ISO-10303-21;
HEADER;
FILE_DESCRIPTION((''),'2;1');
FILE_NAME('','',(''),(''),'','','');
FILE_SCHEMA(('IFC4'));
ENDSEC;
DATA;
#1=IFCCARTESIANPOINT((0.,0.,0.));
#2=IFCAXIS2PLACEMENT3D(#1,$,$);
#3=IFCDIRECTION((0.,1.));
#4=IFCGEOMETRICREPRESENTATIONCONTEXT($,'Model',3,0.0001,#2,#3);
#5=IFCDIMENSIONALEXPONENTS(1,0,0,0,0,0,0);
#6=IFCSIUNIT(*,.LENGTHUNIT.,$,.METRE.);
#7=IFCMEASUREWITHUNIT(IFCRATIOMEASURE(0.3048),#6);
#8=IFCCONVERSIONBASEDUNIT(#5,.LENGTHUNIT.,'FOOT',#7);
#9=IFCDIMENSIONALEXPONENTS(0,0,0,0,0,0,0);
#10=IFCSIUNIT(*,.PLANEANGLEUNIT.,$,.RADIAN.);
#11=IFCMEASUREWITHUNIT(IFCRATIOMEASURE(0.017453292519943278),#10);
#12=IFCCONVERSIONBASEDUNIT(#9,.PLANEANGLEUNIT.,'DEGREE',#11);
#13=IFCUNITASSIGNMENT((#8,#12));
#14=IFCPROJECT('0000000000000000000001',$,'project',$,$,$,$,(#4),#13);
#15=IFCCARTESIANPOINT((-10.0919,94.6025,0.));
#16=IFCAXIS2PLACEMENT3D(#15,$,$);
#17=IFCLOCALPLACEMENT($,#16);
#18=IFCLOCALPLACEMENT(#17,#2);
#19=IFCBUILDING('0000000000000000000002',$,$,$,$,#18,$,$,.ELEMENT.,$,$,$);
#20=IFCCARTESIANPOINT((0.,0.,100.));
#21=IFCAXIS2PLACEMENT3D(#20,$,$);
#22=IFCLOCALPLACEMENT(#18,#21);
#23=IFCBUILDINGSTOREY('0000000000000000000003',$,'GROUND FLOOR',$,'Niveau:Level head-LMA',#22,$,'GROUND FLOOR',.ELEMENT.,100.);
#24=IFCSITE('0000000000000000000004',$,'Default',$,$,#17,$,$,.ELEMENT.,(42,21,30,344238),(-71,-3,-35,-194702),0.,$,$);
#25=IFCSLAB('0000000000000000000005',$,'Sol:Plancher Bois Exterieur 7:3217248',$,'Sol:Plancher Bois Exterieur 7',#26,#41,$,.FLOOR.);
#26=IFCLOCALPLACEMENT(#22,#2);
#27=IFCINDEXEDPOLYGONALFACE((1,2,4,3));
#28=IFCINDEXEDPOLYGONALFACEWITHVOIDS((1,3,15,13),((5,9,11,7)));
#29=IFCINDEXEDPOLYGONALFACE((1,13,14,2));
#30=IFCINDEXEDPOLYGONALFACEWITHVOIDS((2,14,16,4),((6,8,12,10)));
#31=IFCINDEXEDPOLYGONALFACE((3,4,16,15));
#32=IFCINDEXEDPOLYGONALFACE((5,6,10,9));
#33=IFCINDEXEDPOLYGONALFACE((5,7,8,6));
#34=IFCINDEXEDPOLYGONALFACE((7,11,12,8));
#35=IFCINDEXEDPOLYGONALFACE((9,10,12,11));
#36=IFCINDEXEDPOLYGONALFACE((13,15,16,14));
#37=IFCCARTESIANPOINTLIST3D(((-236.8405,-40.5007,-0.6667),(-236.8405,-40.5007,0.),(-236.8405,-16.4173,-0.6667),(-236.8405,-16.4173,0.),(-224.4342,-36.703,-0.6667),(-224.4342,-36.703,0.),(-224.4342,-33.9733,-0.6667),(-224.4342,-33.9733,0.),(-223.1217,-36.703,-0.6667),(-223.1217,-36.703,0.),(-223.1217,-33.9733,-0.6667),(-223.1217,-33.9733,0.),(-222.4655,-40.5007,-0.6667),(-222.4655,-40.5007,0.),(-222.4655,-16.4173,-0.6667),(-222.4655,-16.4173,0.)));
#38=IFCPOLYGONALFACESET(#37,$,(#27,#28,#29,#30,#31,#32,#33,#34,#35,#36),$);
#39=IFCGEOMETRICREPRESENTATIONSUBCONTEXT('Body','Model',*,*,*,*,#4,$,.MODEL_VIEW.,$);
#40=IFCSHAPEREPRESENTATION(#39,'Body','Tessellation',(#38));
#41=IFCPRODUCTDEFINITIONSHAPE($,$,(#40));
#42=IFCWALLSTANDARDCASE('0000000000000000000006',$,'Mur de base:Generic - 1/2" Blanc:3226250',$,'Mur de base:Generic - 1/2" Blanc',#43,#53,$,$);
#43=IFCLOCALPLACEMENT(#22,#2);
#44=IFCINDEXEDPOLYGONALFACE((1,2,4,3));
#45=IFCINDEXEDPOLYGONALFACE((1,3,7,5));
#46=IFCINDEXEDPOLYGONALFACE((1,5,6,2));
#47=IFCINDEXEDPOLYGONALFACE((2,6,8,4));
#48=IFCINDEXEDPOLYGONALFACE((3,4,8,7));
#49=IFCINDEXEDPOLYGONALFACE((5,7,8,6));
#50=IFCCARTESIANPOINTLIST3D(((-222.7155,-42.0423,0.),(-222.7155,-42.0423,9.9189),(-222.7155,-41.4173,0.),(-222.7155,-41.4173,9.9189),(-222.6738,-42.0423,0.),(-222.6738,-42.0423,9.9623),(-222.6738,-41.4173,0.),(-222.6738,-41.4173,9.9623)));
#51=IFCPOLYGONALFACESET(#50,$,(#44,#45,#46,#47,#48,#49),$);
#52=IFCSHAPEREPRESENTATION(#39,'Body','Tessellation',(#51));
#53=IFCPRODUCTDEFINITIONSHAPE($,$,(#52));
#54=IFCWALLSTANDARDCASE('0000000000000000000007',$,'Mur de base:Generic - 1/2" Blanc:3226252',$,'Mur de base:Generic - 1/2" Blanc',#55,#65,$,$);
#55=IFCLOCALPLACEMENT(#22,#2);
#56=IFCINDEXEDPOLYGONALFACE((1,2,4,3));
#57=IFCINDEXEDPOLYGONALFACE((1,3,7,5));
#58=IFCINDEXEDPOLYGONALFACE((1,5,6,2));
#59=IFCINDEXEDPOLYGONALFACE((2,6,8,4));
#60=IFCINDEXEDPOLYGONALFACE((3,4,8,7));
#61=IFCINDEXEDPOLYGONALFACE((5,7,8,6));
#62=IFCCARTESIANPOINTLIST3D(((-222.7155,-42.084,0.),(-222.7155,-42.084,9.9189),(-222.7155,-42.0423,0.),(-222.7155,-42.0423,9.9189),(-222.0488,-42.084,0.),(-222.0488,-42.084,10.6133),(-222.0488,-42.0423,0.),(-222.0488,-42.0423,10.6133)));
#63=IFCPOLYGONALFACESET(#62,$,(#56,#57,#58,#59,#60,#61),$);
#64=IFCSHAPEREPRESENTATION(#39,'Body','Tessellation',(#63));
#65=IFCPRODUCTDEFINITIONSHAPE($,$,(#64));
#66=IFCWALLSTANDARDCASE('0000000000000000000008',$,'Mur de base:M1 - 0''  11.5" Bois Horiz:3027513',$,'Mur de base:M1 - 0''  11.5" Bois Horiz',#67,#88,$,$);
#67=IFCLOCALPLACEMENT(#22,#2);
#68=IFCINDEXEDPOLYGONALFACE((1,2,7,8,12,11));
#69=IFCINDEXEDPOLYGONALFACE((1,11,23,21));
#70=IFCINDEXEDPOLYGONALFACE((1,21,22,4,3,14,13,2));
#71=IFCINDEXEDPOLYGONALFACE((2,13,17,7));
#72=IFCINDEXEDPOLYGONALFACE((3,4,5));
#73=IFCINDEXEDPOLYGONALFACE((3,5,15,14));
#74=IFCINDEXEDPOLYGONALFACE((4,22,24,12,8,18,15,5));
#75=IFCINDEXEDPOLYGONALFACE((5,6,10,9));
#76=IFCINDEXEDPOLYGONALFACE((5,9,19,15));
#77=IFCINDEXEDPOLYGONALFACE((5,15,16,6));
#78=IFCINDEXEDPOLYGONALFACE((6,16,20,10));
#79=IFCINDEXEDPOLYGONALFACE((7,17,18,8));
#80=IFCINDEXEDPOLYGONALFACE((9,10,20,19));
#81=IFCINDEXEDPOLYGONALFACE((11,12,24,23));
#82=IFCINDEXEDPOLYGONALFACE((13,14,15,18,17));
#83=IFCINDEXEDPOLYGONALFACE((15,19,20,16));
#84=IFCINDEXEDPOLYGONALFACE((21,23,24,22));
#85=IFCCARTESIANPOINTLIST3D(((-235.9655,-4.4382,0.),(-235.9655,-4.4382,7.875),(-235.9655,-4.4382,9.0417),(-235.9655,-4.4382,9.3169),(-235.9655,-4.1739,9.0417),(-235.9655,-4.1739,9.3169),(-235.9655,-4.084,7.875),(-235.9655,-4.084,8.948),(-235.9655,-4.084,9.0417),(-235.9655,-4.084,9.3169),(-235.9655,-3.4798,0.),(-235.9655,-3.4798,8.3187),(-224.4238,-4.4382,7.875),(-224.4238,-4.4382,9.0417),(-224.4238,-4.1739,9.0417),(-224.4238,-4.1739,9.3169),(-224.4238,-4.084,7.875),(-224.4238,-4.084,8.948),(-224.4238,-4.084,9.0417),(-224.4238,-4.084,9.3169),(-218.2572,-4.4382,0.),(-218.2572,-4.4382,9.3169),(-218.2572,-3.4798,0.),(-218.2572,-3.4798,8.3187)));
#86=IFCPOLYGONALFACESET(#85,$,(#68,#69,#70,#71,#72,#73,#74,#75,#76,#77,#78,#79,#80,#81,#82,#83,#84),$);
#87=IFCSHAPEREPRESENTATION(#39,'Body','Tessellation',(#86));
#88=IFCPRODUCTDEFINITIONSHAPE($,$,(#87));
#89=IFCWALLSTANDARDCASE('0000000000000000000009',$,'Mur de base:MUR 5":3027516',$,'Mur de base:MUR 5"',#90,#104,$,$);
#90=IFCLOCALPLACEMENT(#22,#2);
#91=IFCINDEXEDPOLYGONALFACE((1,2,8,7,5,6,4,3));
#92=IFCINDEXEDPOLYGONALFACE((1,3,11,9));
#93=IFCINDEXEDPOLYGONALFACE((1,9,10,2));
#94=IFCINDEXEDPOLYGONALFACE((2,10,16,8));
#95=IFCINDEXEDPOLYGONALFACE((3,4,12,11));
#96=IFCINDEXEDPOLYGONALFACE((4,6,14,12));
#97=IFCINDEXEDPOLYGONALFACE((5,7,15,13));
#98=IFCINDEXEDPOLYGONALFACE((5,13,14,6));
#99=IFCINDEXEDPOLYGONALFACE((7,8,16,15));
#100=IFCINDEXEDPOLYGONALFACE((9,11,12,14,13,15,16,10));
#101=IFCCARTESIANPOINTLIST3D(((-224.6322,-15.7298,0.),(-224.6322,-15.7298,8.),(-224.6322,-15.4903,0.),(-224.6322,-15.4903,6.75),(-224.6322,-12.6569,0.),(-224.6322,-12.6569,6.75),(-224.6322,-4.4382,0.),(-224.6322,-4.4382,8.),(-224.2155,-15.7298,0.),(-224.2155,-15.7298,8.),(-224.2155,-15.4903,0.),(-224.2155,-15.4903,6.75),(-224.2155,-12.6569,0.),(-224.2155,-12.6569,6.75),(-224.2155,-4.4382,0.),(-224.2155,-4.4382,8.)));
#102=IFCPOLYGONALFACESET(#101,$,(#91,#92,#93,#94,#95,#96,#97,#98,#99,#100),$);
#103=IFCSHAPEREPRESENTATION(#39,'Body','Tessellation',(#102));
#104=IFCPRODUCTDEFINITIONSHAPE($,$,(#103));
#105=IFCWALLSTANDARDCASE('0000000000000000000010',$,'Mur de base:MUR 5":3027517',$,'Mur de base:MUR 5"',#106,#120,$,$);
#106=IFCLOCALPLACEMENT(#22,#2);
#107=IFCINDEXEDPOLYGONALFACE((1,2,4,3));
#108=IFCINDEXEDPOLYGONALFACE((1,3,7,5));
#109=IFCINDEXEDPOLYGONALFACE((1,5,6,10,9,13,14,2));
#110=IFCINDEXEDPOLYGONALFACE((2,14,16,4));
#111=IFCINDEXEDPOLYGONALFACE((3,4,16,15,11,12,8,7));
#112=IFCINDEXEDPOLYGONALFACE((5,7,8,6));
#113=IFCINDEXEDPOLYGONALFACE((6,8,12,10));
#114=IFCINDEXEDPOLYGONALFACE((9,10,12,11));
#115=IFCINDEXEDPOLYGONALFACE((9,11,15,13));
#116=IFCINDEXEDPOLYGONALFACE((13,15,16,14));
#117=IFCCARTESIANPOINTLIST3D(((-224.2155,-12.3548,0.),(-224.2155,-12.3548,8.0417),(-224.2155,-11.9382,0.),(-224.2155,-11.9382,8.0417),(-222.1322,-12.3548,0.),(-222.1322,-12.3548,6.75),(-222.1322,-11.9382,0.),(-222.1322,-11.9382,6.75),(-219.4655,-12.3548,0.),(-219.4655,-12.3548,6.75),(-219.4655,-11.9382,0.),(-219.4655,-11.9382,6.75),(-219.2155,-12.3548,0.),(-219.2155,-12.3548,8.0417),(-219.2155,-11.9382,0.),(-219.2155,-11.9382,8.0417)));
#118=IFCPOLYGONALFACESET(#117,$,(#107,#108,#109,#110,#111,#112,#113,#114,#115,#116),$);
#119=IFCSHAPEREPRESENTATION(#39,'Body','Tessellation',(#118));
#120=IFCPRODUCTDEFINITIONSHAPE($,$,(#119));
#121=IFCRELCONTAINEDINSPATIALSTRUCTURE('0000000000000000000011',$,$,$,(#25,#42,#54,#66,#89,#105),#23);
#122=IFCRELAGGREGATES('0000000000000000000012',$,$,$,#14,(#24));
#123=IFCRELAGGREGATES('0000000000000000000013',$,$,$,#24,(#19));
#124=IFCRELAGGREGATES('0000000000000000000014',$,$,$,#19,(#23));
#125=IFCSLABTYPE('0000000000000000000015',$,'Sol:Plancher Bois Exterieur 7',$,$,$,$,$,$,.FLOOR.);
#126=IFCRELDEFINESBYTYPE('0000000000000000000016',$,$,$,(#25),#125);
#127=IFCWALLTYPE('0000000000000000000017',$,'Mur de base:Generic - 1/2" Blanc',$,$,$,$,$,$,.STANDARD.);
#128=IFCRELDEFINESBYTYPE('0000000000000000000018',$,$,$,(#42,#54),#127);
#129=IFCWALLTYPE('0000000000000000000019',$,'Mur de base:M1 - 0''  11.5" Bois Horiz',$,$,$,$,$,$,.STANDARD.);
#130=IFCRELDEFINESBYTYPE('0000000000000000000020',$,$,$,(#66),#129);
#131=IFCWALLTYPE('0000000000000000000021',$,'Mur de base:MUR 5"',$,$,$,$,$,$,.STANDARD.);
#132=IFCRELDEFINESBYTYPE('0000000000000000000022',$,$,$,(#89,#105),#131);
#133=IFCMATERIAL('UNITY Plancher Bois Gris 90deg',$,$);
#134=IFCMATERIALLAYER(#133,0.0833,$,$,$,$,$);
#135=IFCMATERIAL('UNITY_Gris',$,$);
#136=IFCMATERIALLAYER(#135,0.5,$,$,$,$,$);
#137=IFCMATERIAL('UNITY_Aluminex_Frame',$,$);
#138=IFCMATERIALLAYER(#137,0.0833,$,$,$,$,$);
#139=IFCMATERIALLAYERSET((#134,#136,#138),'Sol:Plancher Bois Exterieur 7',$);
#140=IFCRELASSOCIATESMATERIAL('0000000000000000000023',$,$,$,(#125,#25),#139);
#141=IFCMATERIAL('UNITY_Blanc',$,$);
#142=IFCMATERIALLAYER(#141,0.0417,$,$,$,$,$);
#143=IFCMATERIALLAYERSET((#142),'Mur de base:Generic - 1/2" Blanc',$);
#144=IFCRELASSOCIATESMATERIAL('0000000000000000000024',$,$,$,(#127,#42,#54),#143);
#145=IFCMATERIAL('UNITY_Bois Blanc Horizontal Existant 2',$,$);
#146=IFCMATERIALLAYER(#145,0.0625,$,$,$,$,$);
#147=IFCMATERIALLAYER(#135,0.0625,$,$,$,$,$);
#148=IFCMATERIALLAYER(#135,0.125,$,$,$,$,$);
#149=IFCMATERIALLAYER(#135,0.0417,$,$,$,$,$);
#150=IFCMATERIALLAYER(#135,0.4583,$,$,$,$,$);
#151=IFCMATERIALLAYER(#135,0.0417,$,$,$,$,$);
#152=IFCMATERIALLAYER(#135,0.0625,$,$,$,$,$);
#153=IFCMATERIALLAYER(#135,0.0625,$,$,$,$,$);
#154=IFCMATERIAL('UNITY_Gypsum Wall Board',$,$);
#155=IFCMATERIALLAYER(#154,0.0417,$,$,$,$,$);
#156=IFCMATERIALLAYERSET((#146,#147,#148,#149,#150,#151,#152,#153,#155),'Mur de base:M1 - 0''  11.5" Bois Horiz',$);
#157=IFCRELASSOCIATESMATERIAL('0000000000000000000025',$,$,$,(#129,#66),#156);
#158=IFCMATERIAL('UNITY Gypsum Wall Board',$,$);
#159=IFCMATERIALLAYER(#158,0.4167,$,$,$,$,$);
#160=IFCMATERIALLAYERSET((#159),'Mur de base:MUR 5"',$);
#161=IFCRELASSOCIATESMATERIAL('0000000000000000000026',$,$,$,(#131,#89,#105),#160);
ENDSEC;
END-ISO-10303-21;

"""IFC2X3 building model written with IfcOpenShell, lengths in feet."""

from ifc_helpers import new_model, entity, si_unit, converted_unit, direction, frame, frame_2d, origin, origin_2d_with_axis, place, context, subcontext, project, spatial, polyline, rectangle, extrude, clip, bounded_halfspace, material, layer, layer_set, layer_usage, type_object, element, save


model = new_model("IFC2X3")

# Units and contexts
model_context = context("Model", 3, precision=0.0001, world=origin(), true_north=direction((0.0, 1.0)))
body_context = subcontext(model_context, "Body", "Model", "MODEL_VIEW")
ifc_project = project(units=[converted_unit("LENGTHUNIT", "FOOT", entity("IfcRatioMeasure", 0.3048), si_unit("LENGTHUNIT", "METRE"), dimensions=[1, 0, 0, 0, 0, 0, 0]), converted_unit("PLANEANGLEUNIT", "DEGREE", entity("IfcRatioMeasure", 0.017453292519943278), si_unit("PLANEANGLEUNIT", "RADIAN"), dimensions=[0, 0, 0, 0, 0, 0, 0])], contexts=[model_context])

# Site, building, storey
site_placement = place(None, frame((-10.0919, 94.6025, 0.0)))
site = spatial("IfcSite", under=ifc_project, at=site_placement, Name="Default", CompositionType="ELEMENT", RefLatitude=(42, 21, 30, 344238), RefLongitude=(-71, -3, -35, -194702), RefElevation=0.0)
building_placement = place(site_placement, origin())
building = spatial("IfcBuilding", under=site, at=building_placement, CompositionType="ELEMENT")
storey_placement = place(building_placement, frame((0.0, 0.0, 100.0)))
storey = spatial("IfcBuildingStorey", under=building, at=storey_placement, Name="GROUND FLOOR", ObjectType="Niveau:Level head-LMA", LongName="GROUND FLOOR", CompositionType="ELEMENT", Elevation=100.0)

# Shared definitions
ifc_material_1 = material(Name="UNITY_Aluminex_Frame")

# Slab, opening
ifc_material_2 = material(Name="UNITY Plancher Bois Gris 90deg")
ifc_layer_1 = layer(ifc_material_2, 0.0833)
ifc_material_3 = material(Name="UNITY_Gris")
ifc_layer_2 = layer(ifc_material_3, 0.5)
ifc_layer_3 = layer(ifc_material_1, 0.0833)
ifc_layer_set_1 = layer_set([ifc_layer_1, ifc_layer_2, ifc_layer_3], Name="Sol:Plancher Bois Exterieur 7")
ifc_layer_usage_1 = layer_usage(ifc_layer_set_1, "AXIS3", "POSITIVE", 0.0)
slab_type = type_object("IfcSlabType", Name="Sol:Plancher Bois Exterieur 7", PredefinedType="FLOOR", material=ifc_layer_set_1)
slab_placement = place(storey_placement, frame((-236.8405, -40.5007, -0.6667)))
slab = element("IfcSlab", 1, at=slab_placement, inside=storey, type_object=slab_type, material=ifc_layer_usage_1, Name="Sol:Plancher Bois Exterieur 7:3217248", ObjectType="Sol:Plancher Bois Exterieur 7", PredefinedType="FLOOR", context=body_context, shape_type="SweptSolid", body=[
    extrude(rectangle(XDim=24.0833, YDim=14.375, at=frame_2d((0.0, 0.0), x_axis=(0.0, 1.0))), frame((7.1875, 12.0417, 0.6667), z_axis=(0.0, 0.0, -1.0), x_axis=(-1.0, 0.0, 0.0)), (0.0, 0.0, 1.0), 0.6667),
])
opening_1_placement = place(slab_placement, frame((13.0625, 5.1625, 0.6667)))
element("IfcOpeningElement", 2, at=opening_1_placement, cuts=slab, ObjectType="Opening", context=body_context, shape_type="SweptSolid", body=[
    extrude(rectangle(XDim=2.7297, YDim=1.3125, at=origin_2d_with_axis()), frame((0.0, 0.0, 0.0), z_axis=(0.0, 0.0, -1.0), x_axis=(0.0, 1.0, 0.0)), (0.0, 0.0, 1.0), 0.6667),
])

# Walls
ifc_material_4 = material(Name="UNITY_Blanc")
ifc_layer_4 = layer(ifc_material_4, 0.0417)
ifc_layer_set_2 = layer_set([ifc_layer_4], Name="Mur de base:Generic - 1/2\" Blanc")
ifc_layer_usage_2 = layer_usage(ifc_layer_set_2, "AXIS2", "POSITIVE", -0.0208)
wall_type_1 = type_object("IfcWallType", Name="Mur de base:Generic - 1/2\" Blanc", PredefinedType="STANDARD", material=ifc_layer_set_2)
wall_1_placement = place(storey_placement, frame((-222.6947, -41.4173, 0.0), z_axis=(0.0, 0.0, 1.0), x_axis=(0.0, -1.0, 0.0)))
element("IfcWallStandardCase", 3, at=wall_1_placement, inside=storey, type_object=wall_type_1, material=ifc_layer_usage_2, Name="Mur de base:Generic - 1/2\" Blanc:3226250", ObjectType="Mur de base:Generic - 1/2\" Blanc", context=body_context, shape_type="Clipping", body=[
    clip(extrude(rectangle(XDim=0.625, YDim=0.0417, at=frame_2d((0.3125, 0.0), x_axis=(-1.0, 0.0))), origin(), (0.0, 0.0, 1.0), 9.9623), bounded_halfspace(frame((0.0, -0.0208, 9.9189), z_axis=(0.0, -0.721387, 0.692532), x_axis=(1.0, 0.0, 0.0)), False, frame((0.0, -0.0208, 9.9189)), polyline([(0.0, 0.0), (0.625, 0.0), (0.625, 0.0417), (0.0, 0.0417), (0.0, 0.0)]))),
])
ifc_layer_usage_3 = layer_usage(ifc_layer_set_2, "AXIS2", "POSITIVE", -0.0208)
wall_2_placement = place(storey_placement, frame((-222.7155, -42.0632, 0.0)))
element("IfcWallStandardCase", 4, at=wall_2_placement, inside=storey, type_object=wall_type_1, material=ifc_layer_usage_3, Name="Mur de base:Generic - 1/2\" Blanc:3226252", ObjectType="Mur de base:Generic - 1/2\" Blanc", context=body_context, shape_type="Clipping", body=[
    clip(extrude(rectangle(XDim=0.6667, YDim=0.0417, at=frame_2d((0.3333, 0.0), x_axis=(-1.0, 0.0))), origin(), (0.0, 0.0, 1.0), 10.6133), bounded_halfspace(frame((0.0, -0.0208, 9.9189), z_axis=(-0.721387, 0.0, 0.692532), x_axis=(0.0, -1.0, 0.0)), False, frame((0.0, -0.0208, 9.9189)), polyline([(0.0, 0.0), (0.6667, 0.0), (0.6667, 0.0417), (0.0417, 0.0417), (0.0, 0.0417), (0.0, 0.0)]))),
])

# Walls, openings
ifc_material_5 = material(Name="UNITY_Bois Blanc Horizontal Existant 2")
ifc_layer_5 = layer(ifc_material_5, 0.0625)
ifc_layer_6 = layer(ifc_material_3, 0.0625)
ifc_layer_7 = layer(ifc_material_3, 0.125)
ifc_layer_8 = layer(ifc_material_3, 0.0417)
ifc_layer_9 = layer(ifc_material_3, 0.4583)
ifc_layer_10 = layer(ifc_material_3, 0.0417)
ifc_layer_11 = layer(ifc_material_3, 0.0625)
ifc_layer_12 = layer(ifc_material_3, 0.0625)
ifc_material_6 = material(Name="UNITY_Gypsum Wall Board")
ifc_layer_13 = layer(ifc_material_6, 0.0417)
ifc_layer_set_3 = layer_set([ifc_layer_5, ifc_layer_6, ifc_layer_7, ifc_layer_8, ifc_layer_9, ifc_layer_10, ifc_layer_11, ifc_layer_12, ifc_layer_13], Name="Mur de base:M1 - 0'  11.5\" Bois Horiz")
wall_type_2 = type_object("IfcWallType", Name="Mur de base:M1 - 0'  11.5\" Bois Horiz", PredefinedType="STANDARD", material=ifc_layer_set_3)
ifc_layer_usage_4 = layer_usage(ifc_layer_set_3, "AXIS2", "NEGATIVE", 0.4792)
wall_3_placement = place(storey_placement, frame((-235.9655, -3.959, 0.0)))
wall_3 = element("IfcWallStandardCase", 5, at=wall_3_placement, inside=storey, type_object=wall_type_2, material=ifc_layer_usage_4, Name="Mur de base:M1 - 0'  11.5\" Bois Horiz:3027513", ObjectType="Mur de base:M1 - 0'  11.5\" Bois Horiz", context=body_context, shape_type="Clipping", body=[
    clip(extrude(rectangle(XDim=17.7083, YDim=0.9583, at=frame_2d((8.8542, 0.0), x_axis=(-1.0, 0.0))), origin(), (0.0, 0.0, 1.0), 9.3169), bounded_halfspace(frame((0.0, -0.4792, 9.3169), z_axis=(0.0, 0.721387, 0.692532), x_axis=(-1.0, 0.0, 0.0)), False, frame((0.0, -0.4792, 9.3169)), polyline([(0.0, 0.0), (11.3333, 0.0), (11.75, 0.0), (16.75, 0.0), (17.7083, 0.0), (17.7083, 0.9583), (0.0, 0.9583), (0.0, 0.3542), (11.5417, 0.3542), (11.5417, 0.2643), (0.0, 0.2643), (0.0, 0.0)]))),
])
opening_2_placement = place(storey_placement, frame((-235.9655, -3.959, 0.0)))
element("IfcOpeningElement", 6, at=opening_2_placement, cuts=wall_3, ObjectType="Opening", context=body_context, shape_type="SweptSolid", body=[
    extrude(rectangle(XDim=0.3542, YDim=11.5417, at=frame_2d((0.0, 0.0), x_axis=(1.0, 0.0))), frame((5.7708, -0.3021, 7.875), z_axis=(0.0, 0.0, 1.0), x_axis=(0.0, 1.0, 0.0)), (0.0, 0.0, 1.0), 1.1667),
])
ifc_material_7 = material(Name="UNITY Gypsum Wall Board")
ifc_layer_14 = layer(ifc_material_7, 0.4167)
ifc_layer_set_4 = layer_set([ifc_layer_14], Name="Mur de base:MUR 5\"")
ifc_layer_usage_5 = layer_usage(ifc_layer_set_4, "AXIS2", "NEGATIVE", 0.2083)
wall_type_3 = type_object("IfcWallType", Name="Mur de base:MUR 5\"", PredefinedType="STANDARD", material=ifc_layer_set_4)
wall_4_placement = place(storey_placement, frame((-224.4238, -15.7298, 0.0), z_axis=(0.0, 0.0, 1.0), x_axis=(0.0, 1.0, 0.0)))
wall_4 = element("IfcWallStandardCase", 7, at=wall_4_placement, inside=storey, type_object=wall_type_3, material=ifc_layer_usage_5, Name="Mur de base:MUR 5\":3027516", ObjectType="Mur de base:MUR 5\"", context=body_context, shape_type="SweptSolid", body=[
    extrude(rectangle(XDim=11.2917, YDim=0.4167, at=frame_2d((5.6458, 0.0), x_axis=(-1.0, 0.0))), origin(), (0.0, 0.0, 1.0), 8.0),
])
opening_3_placement = place(wall_4_placement, frame((15.7298, -224.4238, 0.0), z_axis=(0.0, 0.0, 1.0), x_axis=(0.0, -1.0, 0.0)))
element("IfcOpeningElement", 8, at=opening_3_placement, cuts=wall_4, ObjectType="Opening", context=body_context, shape_type="SweptSolid", body=[
    extrude(rectangle(XDim=6.75, YDim=2.8333, at=frame_2d((0.0, 0.0), x_axis=(1.0, 0.0))), frame((-219.2155, -14.0736, 3.375), z_axis=(-1.0, 0.0, 0.0), x_axis=(0.0, 0.0, 1.0)), (0.0, 0.0, 1.0), 10.0),
])
ifc_layer_usage_6 = layer_usage(ifc_layer_set_4, "AXIS2", "POSITIVE", -0.2083)
wall_5_placement = place(storey_placement, frame((-224.2155, -12.1465, 0.0)))
wall_5 = element("IfcWallStandardCase", 9, at=wall_5_placement, inside=storey, type_object=wall_type_3, material=ifc_layer_usage_6, Name="Mur de base:MUR 5\":3027517", ObjectType="Mur de base:MUR 5\"", context=body_context, shape_type="SweptSolid", body=[
    extrude(rectangle(XDim=5.0, YDim=0.4167, at=frame_2d((2.5, 0.0), x_axis=(-1.0, 0.0))), origin(), (0.0, 0.0, 1.0), 8.0417),
])
opening_4_placement = place(wall_5_placement, frame((224.2155, 12.1465, 0.0)))
element("IfcOpeningElement", 10, at=opening_4_placement, cuts=wall_5, ObjectType="Opening", context=body_context, shape_type="SweptSolid", body=[
    extrude(rectangle(XDim=6.75, YDim=2.6667, at=frame_2d((0.0, 0.0), x_axis=(0.0, 1.0))), frame((-220.7988, -17.3548, 3.375), z_axis=(0.0, 1.0, 0.0), x_axis=(-1.0, 0.0, 0.0)), (0.0, 0.0, 1.0), 10.0),
])

save(model, "model.ifc")
